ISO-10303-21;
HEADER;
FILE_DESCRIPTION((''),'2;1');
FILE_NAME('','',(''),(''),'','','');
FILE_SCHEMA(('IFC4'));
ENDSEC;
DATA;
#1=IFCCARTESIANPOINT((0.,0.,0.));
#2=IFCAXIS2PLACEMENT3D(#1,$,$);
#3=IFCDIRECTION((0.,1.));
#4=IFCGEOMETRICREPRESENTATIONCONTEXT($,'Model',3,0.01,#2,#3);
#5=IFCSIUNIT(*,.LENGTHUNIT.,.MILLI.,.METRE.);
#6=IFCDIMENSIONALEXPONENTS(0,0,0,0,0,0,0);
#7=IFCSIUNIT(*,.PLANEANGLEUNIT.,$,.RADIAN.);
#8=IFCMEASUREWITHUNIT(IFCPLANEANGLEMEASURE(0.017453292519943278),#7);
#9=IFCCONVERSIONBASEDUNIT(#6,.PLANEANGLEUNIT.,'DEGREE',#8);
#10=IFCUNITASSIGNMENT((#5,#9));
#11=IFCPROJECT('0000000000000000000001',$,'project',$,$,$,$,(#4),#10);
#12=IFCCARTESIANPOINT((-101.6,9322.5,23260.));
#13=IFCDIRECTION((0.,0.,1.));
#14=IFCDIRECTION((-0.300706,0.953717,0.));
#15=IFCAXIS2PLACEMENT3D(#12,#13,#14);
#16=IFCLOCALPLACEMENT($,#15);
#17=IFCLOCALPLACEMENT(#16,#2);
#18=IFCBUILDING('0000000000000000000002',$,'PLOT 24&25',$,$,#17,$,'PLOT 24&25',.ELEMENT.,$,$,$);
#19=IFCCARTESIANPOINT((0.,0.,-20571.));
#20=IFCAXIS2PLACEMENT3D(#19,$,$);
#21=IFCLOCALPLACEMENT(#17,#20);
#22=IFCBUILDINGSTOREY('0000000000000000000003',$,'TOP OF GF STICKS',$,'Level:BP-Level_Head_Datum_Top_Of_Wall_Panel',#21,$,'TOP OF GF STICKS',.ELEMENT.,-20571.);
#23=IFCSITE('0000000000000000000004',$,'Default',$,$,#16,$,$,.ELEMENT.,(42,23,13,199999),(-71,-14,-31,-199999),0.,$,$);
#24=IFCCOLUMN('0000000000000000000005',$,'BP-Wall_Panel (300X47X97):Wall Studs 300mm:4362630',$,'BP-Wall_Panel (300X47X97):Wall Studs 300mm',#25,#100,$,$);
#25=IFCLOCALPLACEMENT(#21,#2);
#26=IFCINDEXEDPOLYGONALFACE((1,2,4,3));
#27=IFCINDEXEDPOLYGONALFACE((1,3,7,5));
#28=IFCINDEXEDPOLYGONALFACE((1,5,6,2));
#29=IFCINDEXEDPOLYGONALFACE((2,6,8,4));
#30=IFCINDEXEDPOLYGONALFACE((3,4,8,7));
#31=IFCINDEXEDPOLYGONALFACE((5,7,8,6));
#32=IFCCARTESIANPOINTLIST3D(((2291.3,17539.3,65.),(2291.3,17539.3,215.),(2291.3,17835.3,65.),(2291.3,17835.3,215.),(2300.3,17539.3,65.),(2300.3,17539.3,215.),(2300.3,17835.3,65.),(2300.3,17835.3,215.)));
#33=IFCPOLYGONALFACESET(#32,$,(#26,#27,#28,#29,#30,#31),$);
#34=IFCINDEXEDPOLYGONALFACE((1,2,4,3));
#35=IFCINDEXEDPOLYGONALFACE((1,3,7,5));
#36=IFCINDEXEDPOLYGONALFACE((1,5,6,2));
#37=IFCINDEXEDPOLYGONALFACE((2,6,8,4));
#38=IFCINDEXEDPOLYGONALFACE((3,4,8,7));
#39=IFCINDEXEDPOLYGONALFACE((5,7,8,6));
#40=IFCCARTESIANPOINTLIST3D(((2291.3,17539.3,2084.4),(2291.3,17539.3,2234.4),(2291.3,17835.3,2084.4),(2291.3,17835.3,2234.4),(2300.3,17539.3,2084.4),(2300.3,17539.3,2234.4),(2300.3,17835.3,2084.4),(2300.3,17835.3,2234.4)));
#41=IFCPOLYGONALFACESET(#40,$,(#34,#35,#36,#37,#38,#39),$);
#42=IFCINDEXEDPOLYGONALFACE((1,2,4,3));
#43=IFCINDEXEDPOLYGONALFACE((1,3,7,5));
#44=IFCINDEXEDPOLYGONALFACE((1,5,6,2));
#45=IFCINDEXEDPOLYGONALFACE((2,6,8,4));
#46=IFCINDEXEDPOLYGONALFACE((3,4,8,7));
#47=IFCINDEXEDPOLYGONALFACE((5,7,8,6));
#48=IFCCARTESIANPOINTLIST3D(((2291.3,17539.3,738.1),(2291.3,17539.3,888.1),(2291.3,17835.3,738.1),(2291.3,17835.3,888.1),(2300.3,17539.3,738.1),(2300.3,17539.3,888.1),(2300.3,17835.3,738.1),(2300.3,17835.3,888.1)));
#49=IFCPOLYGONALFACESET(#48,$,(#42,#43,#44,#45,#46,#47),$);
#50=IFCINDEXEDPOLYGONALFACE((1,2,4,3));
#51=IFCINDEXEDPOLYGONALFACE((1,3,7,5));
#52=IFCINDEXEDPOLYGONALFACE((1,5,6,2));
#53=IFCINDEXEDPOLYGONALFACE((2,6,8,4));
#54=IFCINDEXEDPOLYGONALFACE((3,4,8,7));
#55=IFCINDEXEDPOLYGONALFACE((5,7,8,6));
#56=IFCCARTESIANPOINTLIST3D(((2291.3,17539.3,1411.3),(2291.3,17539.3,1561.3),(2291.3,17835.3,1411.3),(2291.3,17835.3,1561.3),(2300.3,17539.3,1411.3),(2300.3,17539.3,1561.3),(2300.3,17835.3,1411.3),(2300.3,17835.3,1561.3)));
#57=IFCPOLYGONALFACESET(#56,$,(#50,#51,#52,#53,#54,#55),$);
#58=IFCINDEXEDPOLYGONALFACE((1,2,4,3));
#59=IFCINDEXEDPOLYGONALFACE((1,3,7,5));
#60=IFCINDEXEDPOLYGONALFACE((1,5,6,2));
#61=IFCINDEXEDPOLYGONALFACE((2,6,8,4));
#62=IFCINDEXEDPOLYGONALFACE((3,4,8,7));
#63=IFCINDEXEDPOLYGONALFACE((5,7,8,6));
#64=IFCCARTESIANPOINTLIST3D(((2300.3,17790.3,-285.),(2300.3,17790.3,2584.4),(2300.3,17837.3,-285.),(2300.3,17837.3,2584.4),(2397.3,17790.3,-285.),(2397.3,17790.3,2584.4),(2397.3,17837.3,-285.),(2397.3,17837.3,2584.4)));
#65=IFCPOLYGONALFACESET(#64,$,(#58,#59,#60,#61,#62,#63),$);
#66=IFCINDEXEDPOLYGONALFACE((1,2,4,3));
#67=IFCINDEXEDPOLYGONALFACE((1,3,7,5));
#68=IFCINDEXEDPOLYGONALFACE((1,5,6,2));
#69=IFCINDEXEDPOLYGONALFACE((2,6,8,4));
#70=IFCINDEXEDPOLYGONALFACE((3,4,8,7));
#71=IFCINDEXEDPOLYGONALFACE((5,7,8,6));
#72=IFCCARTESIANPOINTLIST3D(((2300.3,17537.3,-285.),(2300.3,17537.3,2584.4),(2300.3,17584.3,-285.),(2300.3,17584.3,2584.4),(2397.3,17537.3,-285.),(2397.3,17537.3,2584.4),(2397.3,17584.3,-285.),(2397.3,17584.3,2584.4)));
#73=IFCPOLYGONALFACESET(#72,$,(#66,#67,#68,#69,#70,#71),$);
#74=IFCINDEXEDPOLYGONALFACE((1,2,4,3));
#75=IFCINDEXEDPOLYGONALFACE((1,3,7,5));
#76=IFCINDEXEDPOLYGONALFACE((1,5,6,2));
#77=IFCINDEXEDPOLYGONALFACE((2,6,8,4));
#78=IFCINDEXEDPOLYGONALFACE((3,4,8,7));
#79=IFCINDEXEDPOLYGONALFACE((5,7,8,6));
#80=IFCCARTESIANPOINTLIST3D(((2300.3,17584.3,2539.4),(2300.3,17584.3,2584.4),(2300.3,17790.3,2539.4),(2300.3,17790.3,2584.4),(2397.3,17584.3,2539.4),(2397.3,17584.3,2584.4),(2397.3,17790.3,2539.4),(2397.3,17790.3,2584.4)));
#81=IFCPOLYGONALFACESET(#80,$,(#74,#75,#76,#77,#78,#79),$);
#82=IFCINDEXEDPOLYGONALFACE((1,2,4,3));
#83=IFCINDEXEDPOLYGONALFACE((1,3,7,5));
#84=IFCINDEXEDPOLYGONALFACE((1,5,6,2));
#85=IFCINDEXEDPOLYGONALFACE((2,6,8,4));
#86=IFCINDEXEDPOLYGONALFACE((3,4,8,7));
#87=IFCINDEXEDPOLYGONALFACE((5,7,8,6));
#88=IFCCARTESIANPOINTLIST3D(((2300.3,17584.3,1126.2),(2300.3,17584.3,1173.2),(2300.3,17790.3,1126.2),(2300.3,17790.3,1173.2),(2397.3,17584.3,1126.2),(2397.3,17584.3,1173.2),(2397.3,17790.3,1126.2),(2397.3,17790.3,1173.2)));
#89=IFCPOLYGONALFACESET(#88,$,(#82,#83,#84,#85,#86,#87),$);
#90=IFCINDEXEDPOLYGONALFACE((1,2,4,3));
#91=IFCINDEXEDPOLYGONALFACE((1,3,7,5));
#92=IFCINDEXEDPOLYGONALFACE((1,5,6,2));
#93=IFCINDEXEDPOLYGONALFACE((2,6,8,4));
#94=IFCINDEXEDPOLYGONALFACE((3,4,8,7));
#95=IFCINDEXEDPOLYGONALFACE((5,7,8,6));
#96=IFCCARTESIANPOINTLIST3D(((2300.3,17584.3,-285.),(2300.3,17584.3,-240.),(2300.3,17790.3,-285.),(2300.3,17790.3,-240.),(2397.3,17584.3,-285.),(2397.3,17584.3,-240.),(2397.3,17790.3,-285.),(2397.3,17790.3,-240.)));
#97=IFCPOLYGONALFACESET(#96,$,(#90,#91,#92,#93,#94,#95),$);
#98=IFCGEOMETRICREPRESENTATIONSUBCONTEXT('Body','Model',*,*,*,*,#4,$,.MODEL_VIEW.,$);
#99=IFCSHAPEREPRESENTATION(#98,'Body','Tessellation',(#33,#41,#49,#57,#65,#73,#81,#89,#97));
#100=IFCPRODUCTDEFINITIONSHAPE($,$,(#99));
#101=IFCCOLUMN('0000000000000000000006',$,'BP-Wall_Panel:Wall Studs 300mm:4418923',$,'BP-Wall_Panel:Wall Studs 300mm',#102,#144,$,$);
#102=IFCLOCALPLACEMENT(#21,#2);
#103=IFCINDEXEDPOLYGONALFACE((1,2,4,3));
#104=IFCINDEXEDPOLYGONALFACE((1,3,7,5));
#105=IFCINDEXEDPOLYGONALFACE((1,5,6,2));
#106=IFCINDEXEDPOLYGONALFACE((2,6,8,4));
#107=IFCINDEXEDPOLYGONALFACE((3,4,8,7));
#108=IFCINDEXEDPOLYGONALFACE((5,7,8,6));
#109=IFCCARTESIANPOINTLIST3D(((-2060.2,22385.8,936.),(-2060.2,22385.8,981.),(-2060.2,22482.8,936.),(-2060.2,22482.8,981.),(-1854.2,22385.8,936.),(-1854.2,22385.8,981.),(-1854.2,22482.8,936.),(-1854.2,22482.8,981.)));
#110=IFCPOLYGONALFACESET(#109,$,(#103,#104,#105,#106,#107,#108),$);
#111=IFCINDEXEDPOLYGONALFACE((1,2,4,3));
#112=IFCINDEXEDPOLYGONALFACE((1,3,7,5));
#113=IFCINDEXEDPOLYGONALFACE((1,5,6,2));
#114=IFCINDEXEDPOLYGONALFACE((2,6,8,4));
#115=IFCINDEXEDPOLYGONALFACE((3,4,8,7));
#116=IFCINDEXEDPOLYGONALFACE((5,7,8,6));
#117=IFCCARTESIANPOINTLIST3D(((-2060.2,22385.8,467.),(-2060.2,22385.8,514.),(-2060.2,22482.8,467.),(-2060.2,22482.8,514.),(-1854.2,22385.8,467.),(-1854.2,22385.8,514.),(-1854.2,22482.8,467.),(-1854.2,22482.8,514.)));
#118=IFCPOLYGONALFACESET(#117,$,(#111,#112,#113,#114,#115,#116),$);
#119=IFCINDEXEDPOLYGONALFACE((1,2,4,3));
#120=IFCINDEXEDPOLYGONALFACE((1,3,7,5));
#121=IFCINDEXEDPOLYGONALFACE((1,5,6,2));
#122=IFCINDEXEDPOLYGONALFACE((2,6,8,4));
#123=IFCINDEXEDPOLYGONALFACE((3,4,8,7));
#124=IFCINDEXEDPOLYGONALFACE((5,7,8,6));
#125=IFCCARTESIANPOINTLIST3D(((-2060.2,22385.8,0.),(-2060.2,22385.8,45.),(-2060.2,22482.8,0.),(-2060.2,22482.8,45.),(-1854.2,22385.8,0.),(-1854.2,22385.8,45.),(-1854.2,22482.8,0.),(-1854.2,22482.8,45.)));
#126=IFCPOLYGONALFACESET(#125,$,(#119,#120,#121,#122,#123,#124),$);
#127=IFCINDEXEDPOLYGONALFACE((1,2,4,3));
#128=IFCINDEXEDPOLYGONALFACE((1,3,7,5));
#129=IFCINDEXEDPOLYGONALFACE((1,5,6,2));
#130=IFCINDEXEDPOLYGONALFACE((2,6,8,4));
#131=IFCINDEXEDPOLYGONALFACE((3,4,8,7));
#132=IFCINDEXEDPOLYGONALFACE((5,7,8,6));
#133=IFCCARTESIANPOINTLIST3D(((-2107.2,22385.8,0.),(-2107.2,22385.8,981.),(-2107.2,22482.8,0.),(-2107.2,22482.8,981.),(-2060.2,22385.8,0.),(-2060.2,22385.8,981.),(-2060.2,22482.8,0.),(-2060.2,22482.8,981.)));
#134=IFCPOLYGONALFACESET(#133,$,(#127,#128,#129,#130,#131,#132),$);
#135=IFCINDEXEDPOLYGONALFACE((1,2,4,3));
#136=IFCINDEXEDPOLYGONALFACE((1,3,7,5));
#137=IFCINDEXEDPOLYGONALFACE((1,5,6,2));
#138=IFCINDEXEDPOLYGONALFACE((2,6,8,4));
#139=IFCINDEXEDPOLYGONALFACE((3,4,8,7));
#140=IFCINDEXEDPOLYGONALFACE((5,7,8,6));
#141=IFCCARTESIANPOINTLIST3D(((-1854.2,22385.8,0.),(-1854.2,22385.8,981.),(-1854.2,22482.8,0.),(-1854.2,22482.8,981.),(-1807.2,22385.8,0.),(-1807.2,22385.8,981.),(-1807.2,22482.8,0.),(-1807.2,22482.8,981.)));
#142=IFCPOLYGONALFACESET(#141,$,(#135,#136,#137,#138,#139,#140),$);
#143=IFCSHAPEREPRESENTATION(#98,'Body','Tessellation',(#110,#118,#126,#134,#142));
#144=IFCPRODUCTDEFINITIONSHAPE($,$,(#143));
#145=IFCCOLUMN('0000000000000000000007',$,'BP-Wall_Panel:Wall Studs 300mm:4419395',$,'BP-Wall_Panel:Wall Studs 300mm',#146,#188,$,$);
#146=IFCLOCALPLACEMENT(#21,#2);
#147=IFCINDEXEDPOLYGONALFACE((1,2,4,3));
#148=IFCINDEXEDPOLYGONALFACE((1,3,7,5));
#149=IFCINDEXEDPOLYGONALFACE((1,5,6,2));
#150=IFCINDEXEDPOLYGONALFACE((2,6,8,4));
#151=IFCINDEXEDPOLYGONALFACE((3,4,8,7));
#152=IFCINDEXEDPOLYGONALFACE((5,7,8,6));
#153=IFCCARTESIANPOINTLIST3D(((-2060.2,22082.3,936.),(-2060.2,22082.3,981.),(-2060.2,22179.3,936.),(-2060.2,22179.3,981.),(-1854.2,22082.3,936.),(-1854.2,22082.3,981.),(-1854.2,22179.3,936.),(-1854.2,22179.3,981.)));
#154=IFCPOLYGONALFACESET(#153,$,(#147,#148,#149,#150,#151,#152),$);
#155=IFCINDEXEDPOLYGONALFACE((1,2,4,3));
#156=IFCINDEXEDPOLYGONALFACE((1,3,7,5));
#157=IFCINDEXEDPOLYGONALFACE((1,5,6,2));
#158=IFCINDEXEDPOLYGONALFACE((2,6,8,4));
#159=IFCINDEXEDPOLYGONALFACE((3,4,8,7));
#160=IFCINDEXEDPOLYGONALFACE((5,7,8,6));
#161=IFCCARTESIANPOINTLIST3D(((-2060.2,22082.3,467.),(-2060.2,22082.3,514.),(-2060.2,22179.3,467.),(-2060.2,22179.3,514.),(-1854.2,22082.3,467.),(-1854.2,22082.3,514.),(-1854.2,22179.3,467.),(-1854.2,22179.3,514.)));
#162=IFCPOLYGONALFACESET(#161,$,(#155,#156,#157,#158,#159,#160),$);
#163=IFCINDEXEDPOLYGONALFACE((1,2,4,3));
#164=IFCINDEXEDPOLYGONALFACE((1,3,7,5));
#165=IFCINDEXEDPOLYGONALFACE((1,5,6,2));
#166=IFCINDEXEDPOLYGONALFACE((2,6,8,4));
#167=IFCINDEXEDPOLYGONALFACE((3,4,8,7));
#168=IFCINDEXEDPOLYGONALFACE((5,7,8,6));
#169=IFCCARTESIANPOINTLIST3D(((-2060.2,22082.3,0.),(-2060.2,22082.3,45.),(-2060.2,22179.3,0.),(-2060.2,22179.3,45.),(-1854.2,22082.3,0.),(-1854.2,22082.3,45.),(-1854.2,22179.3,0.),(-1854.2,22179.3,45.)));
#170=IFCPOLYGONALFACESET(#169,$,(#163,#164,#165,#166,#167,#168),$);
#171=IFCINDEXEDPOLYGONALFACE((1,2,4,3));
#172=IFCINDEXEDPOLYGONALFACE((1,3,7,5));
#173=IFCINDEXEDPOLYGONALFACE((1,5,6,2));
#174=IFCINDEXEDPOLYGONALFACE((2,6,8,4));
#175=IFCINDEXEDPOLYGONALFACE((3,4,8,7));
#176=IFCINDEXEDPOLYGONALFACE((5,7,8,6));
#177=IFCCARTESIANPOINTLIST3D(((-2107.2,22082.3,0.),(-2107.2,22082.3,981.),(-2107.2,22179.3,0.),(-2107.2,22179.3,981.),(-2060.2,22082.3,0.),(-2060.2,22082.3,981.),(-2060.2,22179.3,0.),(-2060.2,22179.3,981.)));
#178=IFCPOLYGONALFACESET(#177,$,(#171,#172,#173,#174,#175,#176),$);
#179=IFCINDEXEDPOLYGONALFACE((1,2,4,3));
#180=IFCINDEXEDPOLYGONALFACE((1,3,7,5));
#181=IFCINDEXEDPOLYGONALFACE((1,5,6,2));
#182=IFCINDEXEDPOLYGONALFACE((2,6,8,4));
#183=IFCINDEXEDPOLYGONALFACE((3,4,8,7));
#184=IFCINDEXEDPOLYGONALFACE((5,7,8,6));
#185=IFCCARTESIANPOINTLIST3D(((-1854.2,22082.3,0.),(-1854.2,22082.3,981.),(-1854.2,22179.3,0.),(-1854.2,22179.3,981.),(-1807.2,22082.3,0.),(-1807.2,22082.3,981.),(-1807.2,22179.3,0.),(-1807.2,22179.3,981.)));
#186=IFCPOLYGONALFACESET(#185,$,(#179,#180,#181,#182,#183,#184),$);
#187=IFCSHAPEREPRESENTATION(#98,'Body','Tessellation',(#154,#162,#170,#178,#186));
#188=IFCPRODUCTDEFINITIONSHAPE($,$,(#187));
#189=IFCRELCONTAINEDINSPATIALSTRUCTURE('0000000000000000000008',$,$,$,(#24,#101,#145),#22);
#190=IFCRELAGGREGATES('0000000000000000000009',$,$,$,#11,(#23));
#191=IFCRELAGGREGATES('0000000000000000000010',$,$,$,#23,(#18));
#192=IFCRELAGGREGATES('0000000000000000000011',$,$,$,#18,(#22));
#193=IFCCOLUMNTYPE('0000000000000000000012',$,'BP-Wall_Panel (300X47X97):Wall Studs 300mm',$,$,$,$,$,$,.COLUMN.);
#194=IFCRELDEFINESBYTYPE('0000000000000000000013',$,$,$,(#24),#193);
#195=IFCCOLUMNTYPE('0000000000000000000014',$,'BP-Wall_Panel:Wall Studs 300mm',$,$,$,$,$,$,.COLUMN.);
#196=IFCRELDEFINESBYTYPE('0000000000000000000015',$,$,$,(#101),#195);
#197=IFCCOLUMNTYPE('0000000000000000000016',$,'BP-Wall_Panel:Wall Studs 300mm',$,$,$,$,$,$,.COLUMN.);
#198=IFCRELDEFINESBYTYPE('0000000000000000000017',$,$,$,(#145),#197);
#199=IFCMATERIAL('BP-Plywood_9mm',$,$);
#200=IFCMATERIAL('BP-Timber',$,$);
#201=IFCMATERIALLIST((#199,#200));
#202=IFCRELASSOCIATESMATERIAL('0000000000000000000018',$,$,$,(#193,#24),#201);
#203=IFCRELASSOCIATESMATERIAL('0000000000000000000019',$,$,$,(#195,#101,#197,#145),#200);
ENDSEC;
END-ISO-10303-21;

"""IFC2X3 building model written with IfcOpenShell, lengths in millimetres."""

from ifc_helpers import new_model, entity, si_unit, converted_unit, direction, frame, frame_2d, origin, place, context, subcontext, project, spatial, rectangle, extrude, source, transform, mapped, material, material_list, type_object, type_shapes, element, save


model = new_model("IFC2X3")

# Units and contexts
model_context = context("Model", 3, precision=0.01, world=origin(), true_north=direction((0.0, 1.0)))
body_context = subcontext(model_context, "Body", "Model", "MODEL_VIEW")
ifc_project = project(units=[si_unit("LENGTHUNIT", "METRE", prefix="MILLI"), converted_unit("PLANEANGLEUNIT", "DEGREE", entity("IfcPlaneAngleMeasure", 0.017453292519943278), si_unit("PLANEANGLEUNIT", "RADIAN"), dimensions=[0, 0, 0, 0, 0, 0, 0])], contexts=[model_context])

# Site, building, storey
site_placement = place(None, frame((-101.6, 9322.5, 23260.0), z_axis=(0.0, 0.0, 1.0), x_axis=(-0.300706, 0.953717, 0.0)))
site = spatial("IfcSite", under=ifc_project, at=site_placement, Name="Default", CompositionType="ELEMENT", RefLatitude=(42, 23, 13, 199999), RefLongitude=(-71, -14, -31, -199999), RefElevation=0.0)
building_placement = place(site_placement, origin())
building = spatial("IfcBuilding", under=site, at=building_placement, Name="PLOT 24&25", LongName="PLOT 24&25", CompositionType="ELEMENT")
storey_placement = place(building_placement, frame((0.0, 0.0, -20571.0)))
storey = spatial("IfcBuildingStorey", under=building, at=storey_placement, Name="TOP OF GF STICKS", ObjectType="Level:BP-Level_Head_Datum_Top_Of_Wall_Panel", LongName="TOP OF GF STICKS", CompositionType="ELEMENT", Elevation=-20571.0)

# Columns
ifc_material_1 = material(Name="BP-Plywood_9mm")
ifc_material_2 = material(Name="BP-Timber")
ifc_material_list = material_list([ifc_material_1, ifc_material_2])
column_type_1 = type_object("IfcColumnType", Name="BP-Wall_Panel (300X47X97):Wall Studs 300mm", PredefinedType="COLUMN", material=ifc_material_list)
shared_shape_1 = source(origin(), body_context, "Body", "SweptSolid", [
    extrude(rectangle(XDim=9.0, YDim=296.0, at=frame_2d((0.0, 0.0), x_axis=(1.0, 0.0))), frame((2295.8, 17687.3, -20506.0), z_axis=(0.0, 0.0, 1.0), x_axis=(-1.0, 0.0, 0.0)), (0.0, 0.0, 1.0), 150.0),
    extrude(rectangle(XDim=9.0, YDim=296.0, at=frame_2d((0.0, 0.0), x_axis=(1.0, 0.0))), frame((2295.8, 17687.3, -18486.6), z_axis=(0.0, 0.0, 1.0), x_axis=(-1.0, 0.0, 0.0)), (0.0, 0.0, 1.0), 150.0),
    extrude(rectangle(XDim=9.0, YDim=296.0, at=frame_2d((0.0, 0.0), x_axis=(1.0, 0.0))), frame((2295.8, 17687.3, -19832.9), z_axis=(0.0, 0.0, 1.0), x_axis=(-1.0, 0.0, 0.0)), (0.0, 0.0, 1.0), 150.0),
    extrude(rectangle(XDim=9.0, YDim=296.0, at=frame_2d((0.0, 0.0), x_axis=(1.0, 0.0))), frame((2295.8, 17687.3, -19159.7), z_axis=(0.0, 0.0, 1.0), x_axis=(-1.0, 0.0, 0.0)), (0.0, 0.0, 1.0), 150.0),
    extrude(rectangle(XDim=97.0, YDim=47.0, at=frame_2d((0.0, 0.0), x_axis=(1.0, 0.0))), frame((2348.8, 17813.8, -20856.0), z_axis=(0.0, 0.0, 1.0), x_axis=(-1.0, 0.0, 0.0)), (0.0, 0.0, 1.0), 2869.4),
    extrude(rectangle(XDim=97.0, YDim=47.0, at=frame_2d((0.0, 0.0), x_axis=(1.0, 0.0))), frame((2348.8, 17560.8, -20856.0), z_axis=(0.0, 0.0, 1.0), x_axis=(-1.0, 0.0, 0.0)), (0.0, 0.0, 1.0), 2869.4),
    extrude(rectangle(XDim=206.0, YDim=97.0, at=frame_2d((0.0, 0.0), x_axis=(1.0, 0.0))), frame((2348.8, 17687.3, -18031.6), z_axis=(0.0, 0.0, 1.0), x_axis=(0.0, -1.0, 0.0)), (0.0, 0.0, 1.0), 45.0),
    extrude(rectangle(XDim=206.0, YDim=97.0, at=frame_2d((0.0, 0.0), x_axis=(1.0, 0.0))), frame((2348.8, 17687.3, -19444.8), z_axis=(0.0, 0.0, 1.0), x_axis=(0.0, -1.0, 0.0)), (0.0, 0.0, 1.0), 47.0),
    extrude(rectangle(XDim=206.0, YDim=97.0, at=frame_2d((0.0, 0.0), x_axis=(1.0, 0.0))), frame((2348.8, 17687.3, -20856.0), z_axis=(0.0, 0.0, 1.0), x_axis=(0.0, -1.0, 0.0)), (0.0, 0.0, 1.0), 45.0),
])
type_shapes(column_type_1, [shared_shape_1])
column_1_placement = place(storey_placement, frame((0.0, 0.0, 20571.0)))
element("IfcColumn", 1, at=column_1_placement, inside=storey, type_object=column_type_1, material=ifc_material_list, Name="BP-Wall_Panel (300X47X97):Wall Studs 300mm:4362630", ObjectType="BP-Wall_Panel (300X47X97):Wall Studs 300mm", context=body_context, shape_type="MappedRepresentation", body=[
    mapped(shared_shape_1, transform((0.0, 0.0, 0.0), scale=1.0)),
])
column_type_2 = type_object("IfcColumnType", Name="BP-Wall_Panel:Wall Studs 300mm", PredefinedType="COLUMN", material=ifc_material_2)
shared_shape_2 = source(origin(), body_context, "Body", "SweptSolid", [
    extrude(rectangle(XDim=206.0, YDim=97.0, at=frame_2d((0.0, 0.0), x_axis=(1.0, 0.0))), frame((-1957.2, 22434.3, -19635.0)), (0.0, 0.0, 1.0), 45.0),
    extrude(rectangle(XDim=206.0, YDim=97.0, at=frame_2d((0.0, 0.0), x_axis=(1.0, 0.0))), frame((-1957.2, 22434.3, -20104.0)), (0.0, 0.0, 1.0), 47.0),
    extrude(rectangle(XDim=206.0, YDim=97.0, at=frame_2d((0.0, 0.0), x_axis=(1.0, 0.0))), frame((-1957.2, 22434.3, -20571.0)), (0.0, 0.0, 1.0), 45.0),
    extrude(rectangle(XDim=97.0, YDim=47.0, at=frame_2d((0.0, 0.0), x_axis=(1.0, 0.0))), frame((-2083.7, 22434.3, -20571.0), z_axis=(0.0, 0.0, 1.0), x_axis=(0.0, -1.0, 0.0)), (0.0, 0.0, 1.0), 981.0),
    extrude(rectangle(XDim=97.0, YDim=47.0, at=frame_2d((0.0, 0.0), x_axis=(1.0, 0.0))), frame((-1830.7, 22434.3, -20571.0), z_axis=(0.0, 0.0, 1.0), x_axis=(0.0, -1.0, 0.0)), (0.0, 0.0, 1.0), 981.0),
])
type_shapes(column_type_2, [shared_shape_2])
column_2_placement = place(storey_placement, frame((0.0, 0.0, 20571.0)))
element("IfcColumn", 2, at=column_2_placement, inside=storey, type_object=column_type_2, material=ifc_material_2, Name="BP-Wall_Panel:Wall Studs 300mm:4418923", ObjectType="BP-Wall_Panel:Wall Studs 300mm", context=body_context, shape_type="MappedRepresentation", body=[
    mapped(shared_shape_2, transform((0.0, 0.0, 0.0), scale=1.0)),
])
column_type_3 = type_object("IfcColumnType", Name="BP-Wall_Panel:Wall Studs 300mm", PredefinedType="COLUMN", material=ifc_material_2)
shared_shape_3 = source(origin(), body_context, "Body", "SweptSolid", [
    extrude(rectangle(XDim=206.0, YDim=97.0, at=frame_2d((0.0, 0.0), x_axis=(1.0, 0.0))), frame((-1957.2, 22130.8, -19635.0)), (0.0, 0.0, 1.0), 45.0),
    extrude(rectangle(XDim=206.0, YDim=97.0, at=frame_2d((0.0, 0.0), x_axis=(1.0, 0.0))), frame((-1957.2, 22130.8, -20104.0)), (0.0, 0.0, 1.0), 47.0),
    extrude(rectangle(XDim=206.0, YDim=97.0, at=frame_2d((0.0, 0.0), x_axis=(1.0, 0.0))), frame((-1957.2, 22130.8, -20571.0)), (0.0, 0.0, 1.0), 45.0),
    extrude(rectangle(XDim=97.0, YDim=47.0, at=frame_2d((0.0, 0.0), x_axis=(1.0, 0.0))), frame((-2083.7, 22130.8, -20571.0), z_axis=(0.0, 0.0, 1.0), x_axis=(0.0, -1.0, 0.0)), (0.0, 0.0, 1.0), 981.0),
    extrude(rectangle(XDim=97.0, YDim=47.0, at=frame_2d((0.0, 0.0), x_axis=(1.0, 0.0))), frame((-1830.7, 22130.8, -20571.0), z_axis=(0.0, 0.0, 1.0), x_axis=(0.0, -1.0, 0.0)), (0.0, 0.0, 1.0), 981.0),
])
type_shapes(column_type_3, [shared_shape_3])
column_3_placement = place(storey_placement, frame((0.0, 0.0, 20571.0)))
element("IfcColumn", 3, at=column_3_placement, inside=storey, type_object=column_type_3, material=ifc_material_2, Name="BP-Wall_Panel:Wall Studs 300mm:4419395", ObjectType="BP-Wall_Panel:Wall Studs 300mm", context=body_context, shape_type="MappedRepresentation", body=[
    mapped(shared_shape_3, transform((0.0, 0.0, 0.0), scale=1.0)),
])

save(model, "model.ifc")
